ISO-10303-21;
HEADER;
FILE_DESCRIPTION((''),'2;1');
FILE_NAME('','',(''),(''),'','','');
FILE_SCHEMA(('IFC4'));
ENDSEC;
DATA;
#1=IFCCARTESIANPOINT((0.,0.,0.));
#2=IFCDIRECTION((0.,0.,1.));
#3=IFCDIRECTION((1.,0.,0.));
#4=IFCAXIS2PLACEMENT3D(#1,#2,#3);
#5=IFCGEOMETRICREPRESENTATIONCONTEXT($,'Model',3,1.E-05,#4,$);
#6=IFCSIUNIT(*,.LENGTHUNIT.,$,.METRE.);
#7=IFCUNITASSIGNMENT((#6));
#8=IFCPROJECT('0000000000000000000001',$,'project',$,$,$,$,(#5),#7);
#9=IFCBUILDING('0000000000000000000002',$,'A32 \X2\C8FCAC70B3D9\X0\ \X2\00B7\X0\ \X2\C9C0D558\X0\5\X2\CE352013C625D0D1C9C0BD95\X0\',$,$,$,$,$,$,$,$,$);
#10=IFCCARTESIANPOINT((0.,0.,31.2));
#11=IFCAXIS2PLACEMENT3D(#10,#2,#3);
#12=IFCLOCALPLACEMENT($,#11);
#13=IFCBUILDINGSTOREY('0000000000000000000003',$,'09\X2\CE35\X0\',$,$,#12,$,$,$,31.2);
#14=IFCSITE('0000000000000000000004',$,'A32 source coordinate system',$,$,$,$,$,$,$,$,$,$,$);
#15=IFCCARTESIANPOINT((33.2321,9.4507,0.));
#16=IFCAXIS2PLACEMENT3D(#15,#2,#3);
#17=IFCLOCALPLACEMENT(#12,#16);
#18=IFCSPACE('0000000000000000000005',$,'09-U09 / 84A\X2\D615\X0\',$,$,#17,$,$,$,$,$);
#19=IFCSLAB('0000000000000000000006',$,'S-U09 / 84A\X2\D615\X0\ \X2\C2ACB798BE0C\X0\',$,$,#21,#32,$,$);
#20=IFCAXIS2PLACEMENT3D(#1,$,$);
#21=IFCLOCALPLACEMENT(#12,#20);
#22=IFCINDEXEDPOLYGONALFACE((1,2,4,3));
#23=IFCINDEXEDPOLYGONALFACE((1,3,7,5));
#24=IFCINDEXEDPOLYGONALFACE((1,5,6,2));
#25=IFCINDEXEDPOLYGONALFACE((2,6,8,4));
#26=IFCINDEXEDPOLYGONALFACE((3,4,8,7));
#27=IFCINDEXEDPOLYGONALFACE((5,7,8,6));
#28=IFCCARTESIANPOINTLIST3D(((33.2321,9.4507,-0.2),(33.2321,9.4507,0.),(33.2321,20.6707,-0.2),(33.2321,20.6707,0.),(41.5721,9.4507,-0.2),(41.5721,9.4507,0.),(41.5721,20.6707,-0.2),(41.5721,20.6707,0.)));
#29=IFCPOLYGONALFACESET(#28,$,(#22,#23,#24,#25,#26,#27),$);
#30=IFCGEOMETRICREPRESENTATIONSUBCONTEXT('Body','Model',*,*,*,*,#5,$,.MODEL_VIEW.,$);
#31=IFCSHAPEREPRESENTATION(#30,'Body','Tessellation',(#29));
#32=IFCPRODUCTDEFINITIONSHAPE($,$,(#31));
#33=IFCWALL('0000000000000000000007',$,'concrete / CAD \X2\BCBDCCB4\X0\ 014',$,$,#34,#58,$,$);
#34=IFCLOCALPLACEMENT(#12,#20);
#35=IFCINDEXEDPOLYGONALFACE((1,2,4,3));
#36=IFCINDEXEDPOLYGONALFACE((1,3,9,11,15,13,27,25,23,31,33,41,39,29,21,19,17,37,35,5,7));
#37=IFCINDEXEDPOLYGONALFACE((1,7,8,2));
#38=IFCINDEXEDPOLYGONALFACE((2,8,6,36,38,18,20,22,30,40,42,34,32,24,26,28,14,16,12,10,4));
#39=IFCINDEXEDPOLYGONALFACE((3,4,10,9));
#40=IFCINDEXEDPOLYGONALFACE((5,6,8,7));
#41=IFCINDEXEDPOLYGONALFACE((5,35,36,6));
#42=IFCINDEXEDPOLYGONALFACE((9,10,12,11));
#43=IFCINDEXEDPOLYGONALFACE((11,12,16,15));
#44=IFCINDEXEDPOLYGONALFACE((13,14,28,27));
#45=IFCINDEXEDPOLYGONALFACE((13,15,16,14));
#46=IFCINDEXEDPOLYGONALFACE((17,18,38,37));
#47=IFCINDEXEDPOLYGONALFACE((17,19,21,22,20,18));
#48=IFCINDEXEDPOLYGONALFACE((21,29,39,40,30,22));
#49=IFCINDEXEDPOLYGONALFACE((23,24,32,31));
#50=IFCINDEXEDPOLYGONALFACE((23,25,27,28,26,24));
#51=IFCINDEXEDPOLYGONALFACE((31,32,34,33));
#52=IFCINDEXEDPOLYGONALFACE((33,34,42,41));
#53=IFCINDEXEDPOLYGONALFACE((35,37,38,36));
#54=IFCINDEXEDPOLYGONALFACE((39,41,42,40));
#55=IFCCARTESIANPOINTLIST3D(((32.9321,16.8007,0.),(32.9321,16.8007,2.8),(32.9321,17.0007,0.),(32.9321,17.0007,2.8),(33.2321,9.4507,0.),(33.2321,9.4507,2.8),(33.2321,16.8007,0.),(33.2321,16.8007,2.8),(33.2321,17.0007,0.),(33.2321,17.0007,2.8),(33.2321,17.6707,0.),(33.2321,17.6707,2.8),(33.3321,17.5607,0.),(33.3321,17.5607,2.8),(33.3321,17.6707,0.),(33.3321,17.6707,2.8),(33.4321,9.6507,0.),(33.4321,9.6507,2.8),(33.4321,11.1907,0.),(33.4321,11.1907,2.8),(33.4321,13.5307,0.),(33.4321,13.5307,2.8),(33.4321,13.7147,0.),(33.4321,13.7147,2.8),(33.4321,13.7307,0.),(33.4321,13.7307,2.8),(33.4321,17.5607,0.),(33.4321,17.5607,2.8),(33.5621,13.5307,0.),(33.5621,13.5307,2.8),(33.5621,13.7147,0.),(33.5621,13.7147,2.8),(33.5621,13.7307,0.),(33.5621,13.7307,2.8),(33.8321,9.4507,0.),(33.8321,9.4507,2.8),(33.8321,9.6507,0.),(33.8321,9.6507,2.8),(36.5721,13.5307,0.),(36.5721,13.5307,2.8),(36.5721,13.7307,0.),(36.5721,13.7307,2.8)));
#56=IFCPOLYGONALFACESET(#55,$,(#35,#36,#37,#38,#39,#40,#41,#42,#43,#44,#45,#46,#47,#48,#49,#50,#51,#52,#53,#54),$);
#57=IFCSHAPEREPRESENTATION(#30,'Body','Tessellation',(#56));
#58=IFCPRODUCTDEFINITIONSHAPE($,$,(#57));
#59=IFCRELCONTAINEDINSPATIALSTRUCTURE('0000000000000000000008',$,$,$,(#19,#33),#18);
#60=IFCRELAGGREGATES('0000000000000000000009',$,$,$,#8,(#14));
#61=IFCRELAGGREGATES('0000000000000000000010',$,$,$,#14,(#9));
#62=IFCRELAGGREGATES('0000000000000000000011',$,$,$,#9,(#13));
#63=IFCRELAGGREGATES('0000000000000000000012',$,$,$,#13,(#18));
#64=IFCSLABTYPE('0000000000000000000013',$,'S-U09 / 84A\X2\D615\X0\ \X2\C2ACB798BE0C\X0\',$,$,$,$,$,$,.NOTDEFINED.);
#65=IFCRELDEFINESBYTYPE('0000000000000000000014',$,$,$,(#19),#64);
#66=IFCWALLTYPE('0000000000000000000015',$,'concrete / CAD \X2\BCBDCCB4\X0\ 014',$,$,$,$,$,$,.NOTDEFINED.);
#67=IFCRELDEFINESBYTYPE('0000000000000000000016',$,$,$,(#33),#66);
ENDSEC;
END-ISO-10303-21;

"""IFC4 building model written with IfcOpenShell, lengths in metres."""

from ifc_helpers import new_model, si_unit, frame, origin, origin_with_axes, place, context, subcontext, project, spatial, polyline, outline, extrude, source, transform, mapped, type_object, type_shapes, element, save


model = new_model("IFC4")

# Units and contexts
model_context = context("Model", 3, precision=1e-05, world=origin_with_axes())
body_context = subcontext(model_context, "Body", "Model", "MODEL_VIEW")
ifc_project = project(units=[si_unit("LENGTHUNIT", "METRE")], contexts=[model_context])

# Site, building, storey, space
storey_placement = place(None, frame((0.0, 0.0, 31.2), z_axis=(0.0, 0.0, 1.0), x_axis=(1.0, 0.0, 0.0)))
space_placement = place(storey_placement, frame((33.2321, 9.4507, 0.0), z_axis=(0.0, 0.0, 1.0), x_axis=(1.0, 0.0, 0.0)))
site = spatial("IfcSite", under=ifc_project, Name="A32 source coordinate system")
building = spatial("IfcBuilding", under=site, Name="A32 주거동 · 지하5층–옥탑지붕")
storey = spatial("IfcBuildingStorey", under=building, at=storey_placement, Name="09층", Elevation=31.2)
space = spatial("IfcSpace", under=storey, at=space_placement, Name="09-U09 / 84A형")

# Slab
slab_type_1 = type_object("IfcSlabType", Name="S-U09 / 84A형 슬래브", PredefinedType="NOTDEFINED")
shared_shape_1 = source(origin(), body_context, "Body", "SweptSolid", [
    extrude(outline(polyline([(0.0, 11.22), (8.34, 11.22), (8.34, 0.0), (0.0, 0.0), (0.0, 11.22)])), frame((0.0, 0.0, -0.2)), (0.0, 0.0, 1.0), 0.2),
])
type_shapes(slab_type_1, [shared_shape_1])
slab_1_placement = place(space_placement, origin_with_axes())
element("IfcSlab", 1, at=slab_1_placement, inside=space, type_object=slab_type_1, Name="S-U09 / 84A형 슬래브", context=body_context, shape_type="MappedRepresentation", body=[
    mapped(shared_shape_1, transform((0.0, 0.0, 0.0), scale=1.0)),
])

# Wall
wall_type_1 = type_object("IfcWallType", Name="concrete / CAD 벽체 014", PredefinedType="NOTDEFINED")
shared_shape_2 = source(origin(), body_context, "Body", "SweptSolid", [
    extrude(outline(polyline([(3.34, 4.08), (0.33, 4.08), (0.2, 4.08), (0.2, 1.74), (0.2, 0.2), (0.6, 0.2), (0.6, 0.0), (0.0, 0.0), (0.0, 7.35), (-0.3, 7.35), (-0.3, 7.55), (0.0, 7.55), (0.0, 8.22), (0.1, 8.22), (0.1, 8.11), (0.2, 8.11), (0.2, 4.28), (0.2, 4.264), (0.33, 4.264), (0.33, 4.28), (3.34, 4.28), (3.34, 4.08)])), origin(), (0.0, 0.0, 1.0), 2.8),
])
type_shapes(wall_type_1, [shared_shape_2])
wall_1_placement = place(space_placement, origin_with_axes())
element("IfcWall", 2, at=wall_1_placement, inside=space, type_object=wall_type_1, Name="concrete / CAD 벽체 014", context=body_context, shape_type="MappedRepresentation", body=[
    mapped(shared_shape_2, transform((0.0, 0.0, 0.0), scale=1.0)),
])

save(model, "model.ifc")
